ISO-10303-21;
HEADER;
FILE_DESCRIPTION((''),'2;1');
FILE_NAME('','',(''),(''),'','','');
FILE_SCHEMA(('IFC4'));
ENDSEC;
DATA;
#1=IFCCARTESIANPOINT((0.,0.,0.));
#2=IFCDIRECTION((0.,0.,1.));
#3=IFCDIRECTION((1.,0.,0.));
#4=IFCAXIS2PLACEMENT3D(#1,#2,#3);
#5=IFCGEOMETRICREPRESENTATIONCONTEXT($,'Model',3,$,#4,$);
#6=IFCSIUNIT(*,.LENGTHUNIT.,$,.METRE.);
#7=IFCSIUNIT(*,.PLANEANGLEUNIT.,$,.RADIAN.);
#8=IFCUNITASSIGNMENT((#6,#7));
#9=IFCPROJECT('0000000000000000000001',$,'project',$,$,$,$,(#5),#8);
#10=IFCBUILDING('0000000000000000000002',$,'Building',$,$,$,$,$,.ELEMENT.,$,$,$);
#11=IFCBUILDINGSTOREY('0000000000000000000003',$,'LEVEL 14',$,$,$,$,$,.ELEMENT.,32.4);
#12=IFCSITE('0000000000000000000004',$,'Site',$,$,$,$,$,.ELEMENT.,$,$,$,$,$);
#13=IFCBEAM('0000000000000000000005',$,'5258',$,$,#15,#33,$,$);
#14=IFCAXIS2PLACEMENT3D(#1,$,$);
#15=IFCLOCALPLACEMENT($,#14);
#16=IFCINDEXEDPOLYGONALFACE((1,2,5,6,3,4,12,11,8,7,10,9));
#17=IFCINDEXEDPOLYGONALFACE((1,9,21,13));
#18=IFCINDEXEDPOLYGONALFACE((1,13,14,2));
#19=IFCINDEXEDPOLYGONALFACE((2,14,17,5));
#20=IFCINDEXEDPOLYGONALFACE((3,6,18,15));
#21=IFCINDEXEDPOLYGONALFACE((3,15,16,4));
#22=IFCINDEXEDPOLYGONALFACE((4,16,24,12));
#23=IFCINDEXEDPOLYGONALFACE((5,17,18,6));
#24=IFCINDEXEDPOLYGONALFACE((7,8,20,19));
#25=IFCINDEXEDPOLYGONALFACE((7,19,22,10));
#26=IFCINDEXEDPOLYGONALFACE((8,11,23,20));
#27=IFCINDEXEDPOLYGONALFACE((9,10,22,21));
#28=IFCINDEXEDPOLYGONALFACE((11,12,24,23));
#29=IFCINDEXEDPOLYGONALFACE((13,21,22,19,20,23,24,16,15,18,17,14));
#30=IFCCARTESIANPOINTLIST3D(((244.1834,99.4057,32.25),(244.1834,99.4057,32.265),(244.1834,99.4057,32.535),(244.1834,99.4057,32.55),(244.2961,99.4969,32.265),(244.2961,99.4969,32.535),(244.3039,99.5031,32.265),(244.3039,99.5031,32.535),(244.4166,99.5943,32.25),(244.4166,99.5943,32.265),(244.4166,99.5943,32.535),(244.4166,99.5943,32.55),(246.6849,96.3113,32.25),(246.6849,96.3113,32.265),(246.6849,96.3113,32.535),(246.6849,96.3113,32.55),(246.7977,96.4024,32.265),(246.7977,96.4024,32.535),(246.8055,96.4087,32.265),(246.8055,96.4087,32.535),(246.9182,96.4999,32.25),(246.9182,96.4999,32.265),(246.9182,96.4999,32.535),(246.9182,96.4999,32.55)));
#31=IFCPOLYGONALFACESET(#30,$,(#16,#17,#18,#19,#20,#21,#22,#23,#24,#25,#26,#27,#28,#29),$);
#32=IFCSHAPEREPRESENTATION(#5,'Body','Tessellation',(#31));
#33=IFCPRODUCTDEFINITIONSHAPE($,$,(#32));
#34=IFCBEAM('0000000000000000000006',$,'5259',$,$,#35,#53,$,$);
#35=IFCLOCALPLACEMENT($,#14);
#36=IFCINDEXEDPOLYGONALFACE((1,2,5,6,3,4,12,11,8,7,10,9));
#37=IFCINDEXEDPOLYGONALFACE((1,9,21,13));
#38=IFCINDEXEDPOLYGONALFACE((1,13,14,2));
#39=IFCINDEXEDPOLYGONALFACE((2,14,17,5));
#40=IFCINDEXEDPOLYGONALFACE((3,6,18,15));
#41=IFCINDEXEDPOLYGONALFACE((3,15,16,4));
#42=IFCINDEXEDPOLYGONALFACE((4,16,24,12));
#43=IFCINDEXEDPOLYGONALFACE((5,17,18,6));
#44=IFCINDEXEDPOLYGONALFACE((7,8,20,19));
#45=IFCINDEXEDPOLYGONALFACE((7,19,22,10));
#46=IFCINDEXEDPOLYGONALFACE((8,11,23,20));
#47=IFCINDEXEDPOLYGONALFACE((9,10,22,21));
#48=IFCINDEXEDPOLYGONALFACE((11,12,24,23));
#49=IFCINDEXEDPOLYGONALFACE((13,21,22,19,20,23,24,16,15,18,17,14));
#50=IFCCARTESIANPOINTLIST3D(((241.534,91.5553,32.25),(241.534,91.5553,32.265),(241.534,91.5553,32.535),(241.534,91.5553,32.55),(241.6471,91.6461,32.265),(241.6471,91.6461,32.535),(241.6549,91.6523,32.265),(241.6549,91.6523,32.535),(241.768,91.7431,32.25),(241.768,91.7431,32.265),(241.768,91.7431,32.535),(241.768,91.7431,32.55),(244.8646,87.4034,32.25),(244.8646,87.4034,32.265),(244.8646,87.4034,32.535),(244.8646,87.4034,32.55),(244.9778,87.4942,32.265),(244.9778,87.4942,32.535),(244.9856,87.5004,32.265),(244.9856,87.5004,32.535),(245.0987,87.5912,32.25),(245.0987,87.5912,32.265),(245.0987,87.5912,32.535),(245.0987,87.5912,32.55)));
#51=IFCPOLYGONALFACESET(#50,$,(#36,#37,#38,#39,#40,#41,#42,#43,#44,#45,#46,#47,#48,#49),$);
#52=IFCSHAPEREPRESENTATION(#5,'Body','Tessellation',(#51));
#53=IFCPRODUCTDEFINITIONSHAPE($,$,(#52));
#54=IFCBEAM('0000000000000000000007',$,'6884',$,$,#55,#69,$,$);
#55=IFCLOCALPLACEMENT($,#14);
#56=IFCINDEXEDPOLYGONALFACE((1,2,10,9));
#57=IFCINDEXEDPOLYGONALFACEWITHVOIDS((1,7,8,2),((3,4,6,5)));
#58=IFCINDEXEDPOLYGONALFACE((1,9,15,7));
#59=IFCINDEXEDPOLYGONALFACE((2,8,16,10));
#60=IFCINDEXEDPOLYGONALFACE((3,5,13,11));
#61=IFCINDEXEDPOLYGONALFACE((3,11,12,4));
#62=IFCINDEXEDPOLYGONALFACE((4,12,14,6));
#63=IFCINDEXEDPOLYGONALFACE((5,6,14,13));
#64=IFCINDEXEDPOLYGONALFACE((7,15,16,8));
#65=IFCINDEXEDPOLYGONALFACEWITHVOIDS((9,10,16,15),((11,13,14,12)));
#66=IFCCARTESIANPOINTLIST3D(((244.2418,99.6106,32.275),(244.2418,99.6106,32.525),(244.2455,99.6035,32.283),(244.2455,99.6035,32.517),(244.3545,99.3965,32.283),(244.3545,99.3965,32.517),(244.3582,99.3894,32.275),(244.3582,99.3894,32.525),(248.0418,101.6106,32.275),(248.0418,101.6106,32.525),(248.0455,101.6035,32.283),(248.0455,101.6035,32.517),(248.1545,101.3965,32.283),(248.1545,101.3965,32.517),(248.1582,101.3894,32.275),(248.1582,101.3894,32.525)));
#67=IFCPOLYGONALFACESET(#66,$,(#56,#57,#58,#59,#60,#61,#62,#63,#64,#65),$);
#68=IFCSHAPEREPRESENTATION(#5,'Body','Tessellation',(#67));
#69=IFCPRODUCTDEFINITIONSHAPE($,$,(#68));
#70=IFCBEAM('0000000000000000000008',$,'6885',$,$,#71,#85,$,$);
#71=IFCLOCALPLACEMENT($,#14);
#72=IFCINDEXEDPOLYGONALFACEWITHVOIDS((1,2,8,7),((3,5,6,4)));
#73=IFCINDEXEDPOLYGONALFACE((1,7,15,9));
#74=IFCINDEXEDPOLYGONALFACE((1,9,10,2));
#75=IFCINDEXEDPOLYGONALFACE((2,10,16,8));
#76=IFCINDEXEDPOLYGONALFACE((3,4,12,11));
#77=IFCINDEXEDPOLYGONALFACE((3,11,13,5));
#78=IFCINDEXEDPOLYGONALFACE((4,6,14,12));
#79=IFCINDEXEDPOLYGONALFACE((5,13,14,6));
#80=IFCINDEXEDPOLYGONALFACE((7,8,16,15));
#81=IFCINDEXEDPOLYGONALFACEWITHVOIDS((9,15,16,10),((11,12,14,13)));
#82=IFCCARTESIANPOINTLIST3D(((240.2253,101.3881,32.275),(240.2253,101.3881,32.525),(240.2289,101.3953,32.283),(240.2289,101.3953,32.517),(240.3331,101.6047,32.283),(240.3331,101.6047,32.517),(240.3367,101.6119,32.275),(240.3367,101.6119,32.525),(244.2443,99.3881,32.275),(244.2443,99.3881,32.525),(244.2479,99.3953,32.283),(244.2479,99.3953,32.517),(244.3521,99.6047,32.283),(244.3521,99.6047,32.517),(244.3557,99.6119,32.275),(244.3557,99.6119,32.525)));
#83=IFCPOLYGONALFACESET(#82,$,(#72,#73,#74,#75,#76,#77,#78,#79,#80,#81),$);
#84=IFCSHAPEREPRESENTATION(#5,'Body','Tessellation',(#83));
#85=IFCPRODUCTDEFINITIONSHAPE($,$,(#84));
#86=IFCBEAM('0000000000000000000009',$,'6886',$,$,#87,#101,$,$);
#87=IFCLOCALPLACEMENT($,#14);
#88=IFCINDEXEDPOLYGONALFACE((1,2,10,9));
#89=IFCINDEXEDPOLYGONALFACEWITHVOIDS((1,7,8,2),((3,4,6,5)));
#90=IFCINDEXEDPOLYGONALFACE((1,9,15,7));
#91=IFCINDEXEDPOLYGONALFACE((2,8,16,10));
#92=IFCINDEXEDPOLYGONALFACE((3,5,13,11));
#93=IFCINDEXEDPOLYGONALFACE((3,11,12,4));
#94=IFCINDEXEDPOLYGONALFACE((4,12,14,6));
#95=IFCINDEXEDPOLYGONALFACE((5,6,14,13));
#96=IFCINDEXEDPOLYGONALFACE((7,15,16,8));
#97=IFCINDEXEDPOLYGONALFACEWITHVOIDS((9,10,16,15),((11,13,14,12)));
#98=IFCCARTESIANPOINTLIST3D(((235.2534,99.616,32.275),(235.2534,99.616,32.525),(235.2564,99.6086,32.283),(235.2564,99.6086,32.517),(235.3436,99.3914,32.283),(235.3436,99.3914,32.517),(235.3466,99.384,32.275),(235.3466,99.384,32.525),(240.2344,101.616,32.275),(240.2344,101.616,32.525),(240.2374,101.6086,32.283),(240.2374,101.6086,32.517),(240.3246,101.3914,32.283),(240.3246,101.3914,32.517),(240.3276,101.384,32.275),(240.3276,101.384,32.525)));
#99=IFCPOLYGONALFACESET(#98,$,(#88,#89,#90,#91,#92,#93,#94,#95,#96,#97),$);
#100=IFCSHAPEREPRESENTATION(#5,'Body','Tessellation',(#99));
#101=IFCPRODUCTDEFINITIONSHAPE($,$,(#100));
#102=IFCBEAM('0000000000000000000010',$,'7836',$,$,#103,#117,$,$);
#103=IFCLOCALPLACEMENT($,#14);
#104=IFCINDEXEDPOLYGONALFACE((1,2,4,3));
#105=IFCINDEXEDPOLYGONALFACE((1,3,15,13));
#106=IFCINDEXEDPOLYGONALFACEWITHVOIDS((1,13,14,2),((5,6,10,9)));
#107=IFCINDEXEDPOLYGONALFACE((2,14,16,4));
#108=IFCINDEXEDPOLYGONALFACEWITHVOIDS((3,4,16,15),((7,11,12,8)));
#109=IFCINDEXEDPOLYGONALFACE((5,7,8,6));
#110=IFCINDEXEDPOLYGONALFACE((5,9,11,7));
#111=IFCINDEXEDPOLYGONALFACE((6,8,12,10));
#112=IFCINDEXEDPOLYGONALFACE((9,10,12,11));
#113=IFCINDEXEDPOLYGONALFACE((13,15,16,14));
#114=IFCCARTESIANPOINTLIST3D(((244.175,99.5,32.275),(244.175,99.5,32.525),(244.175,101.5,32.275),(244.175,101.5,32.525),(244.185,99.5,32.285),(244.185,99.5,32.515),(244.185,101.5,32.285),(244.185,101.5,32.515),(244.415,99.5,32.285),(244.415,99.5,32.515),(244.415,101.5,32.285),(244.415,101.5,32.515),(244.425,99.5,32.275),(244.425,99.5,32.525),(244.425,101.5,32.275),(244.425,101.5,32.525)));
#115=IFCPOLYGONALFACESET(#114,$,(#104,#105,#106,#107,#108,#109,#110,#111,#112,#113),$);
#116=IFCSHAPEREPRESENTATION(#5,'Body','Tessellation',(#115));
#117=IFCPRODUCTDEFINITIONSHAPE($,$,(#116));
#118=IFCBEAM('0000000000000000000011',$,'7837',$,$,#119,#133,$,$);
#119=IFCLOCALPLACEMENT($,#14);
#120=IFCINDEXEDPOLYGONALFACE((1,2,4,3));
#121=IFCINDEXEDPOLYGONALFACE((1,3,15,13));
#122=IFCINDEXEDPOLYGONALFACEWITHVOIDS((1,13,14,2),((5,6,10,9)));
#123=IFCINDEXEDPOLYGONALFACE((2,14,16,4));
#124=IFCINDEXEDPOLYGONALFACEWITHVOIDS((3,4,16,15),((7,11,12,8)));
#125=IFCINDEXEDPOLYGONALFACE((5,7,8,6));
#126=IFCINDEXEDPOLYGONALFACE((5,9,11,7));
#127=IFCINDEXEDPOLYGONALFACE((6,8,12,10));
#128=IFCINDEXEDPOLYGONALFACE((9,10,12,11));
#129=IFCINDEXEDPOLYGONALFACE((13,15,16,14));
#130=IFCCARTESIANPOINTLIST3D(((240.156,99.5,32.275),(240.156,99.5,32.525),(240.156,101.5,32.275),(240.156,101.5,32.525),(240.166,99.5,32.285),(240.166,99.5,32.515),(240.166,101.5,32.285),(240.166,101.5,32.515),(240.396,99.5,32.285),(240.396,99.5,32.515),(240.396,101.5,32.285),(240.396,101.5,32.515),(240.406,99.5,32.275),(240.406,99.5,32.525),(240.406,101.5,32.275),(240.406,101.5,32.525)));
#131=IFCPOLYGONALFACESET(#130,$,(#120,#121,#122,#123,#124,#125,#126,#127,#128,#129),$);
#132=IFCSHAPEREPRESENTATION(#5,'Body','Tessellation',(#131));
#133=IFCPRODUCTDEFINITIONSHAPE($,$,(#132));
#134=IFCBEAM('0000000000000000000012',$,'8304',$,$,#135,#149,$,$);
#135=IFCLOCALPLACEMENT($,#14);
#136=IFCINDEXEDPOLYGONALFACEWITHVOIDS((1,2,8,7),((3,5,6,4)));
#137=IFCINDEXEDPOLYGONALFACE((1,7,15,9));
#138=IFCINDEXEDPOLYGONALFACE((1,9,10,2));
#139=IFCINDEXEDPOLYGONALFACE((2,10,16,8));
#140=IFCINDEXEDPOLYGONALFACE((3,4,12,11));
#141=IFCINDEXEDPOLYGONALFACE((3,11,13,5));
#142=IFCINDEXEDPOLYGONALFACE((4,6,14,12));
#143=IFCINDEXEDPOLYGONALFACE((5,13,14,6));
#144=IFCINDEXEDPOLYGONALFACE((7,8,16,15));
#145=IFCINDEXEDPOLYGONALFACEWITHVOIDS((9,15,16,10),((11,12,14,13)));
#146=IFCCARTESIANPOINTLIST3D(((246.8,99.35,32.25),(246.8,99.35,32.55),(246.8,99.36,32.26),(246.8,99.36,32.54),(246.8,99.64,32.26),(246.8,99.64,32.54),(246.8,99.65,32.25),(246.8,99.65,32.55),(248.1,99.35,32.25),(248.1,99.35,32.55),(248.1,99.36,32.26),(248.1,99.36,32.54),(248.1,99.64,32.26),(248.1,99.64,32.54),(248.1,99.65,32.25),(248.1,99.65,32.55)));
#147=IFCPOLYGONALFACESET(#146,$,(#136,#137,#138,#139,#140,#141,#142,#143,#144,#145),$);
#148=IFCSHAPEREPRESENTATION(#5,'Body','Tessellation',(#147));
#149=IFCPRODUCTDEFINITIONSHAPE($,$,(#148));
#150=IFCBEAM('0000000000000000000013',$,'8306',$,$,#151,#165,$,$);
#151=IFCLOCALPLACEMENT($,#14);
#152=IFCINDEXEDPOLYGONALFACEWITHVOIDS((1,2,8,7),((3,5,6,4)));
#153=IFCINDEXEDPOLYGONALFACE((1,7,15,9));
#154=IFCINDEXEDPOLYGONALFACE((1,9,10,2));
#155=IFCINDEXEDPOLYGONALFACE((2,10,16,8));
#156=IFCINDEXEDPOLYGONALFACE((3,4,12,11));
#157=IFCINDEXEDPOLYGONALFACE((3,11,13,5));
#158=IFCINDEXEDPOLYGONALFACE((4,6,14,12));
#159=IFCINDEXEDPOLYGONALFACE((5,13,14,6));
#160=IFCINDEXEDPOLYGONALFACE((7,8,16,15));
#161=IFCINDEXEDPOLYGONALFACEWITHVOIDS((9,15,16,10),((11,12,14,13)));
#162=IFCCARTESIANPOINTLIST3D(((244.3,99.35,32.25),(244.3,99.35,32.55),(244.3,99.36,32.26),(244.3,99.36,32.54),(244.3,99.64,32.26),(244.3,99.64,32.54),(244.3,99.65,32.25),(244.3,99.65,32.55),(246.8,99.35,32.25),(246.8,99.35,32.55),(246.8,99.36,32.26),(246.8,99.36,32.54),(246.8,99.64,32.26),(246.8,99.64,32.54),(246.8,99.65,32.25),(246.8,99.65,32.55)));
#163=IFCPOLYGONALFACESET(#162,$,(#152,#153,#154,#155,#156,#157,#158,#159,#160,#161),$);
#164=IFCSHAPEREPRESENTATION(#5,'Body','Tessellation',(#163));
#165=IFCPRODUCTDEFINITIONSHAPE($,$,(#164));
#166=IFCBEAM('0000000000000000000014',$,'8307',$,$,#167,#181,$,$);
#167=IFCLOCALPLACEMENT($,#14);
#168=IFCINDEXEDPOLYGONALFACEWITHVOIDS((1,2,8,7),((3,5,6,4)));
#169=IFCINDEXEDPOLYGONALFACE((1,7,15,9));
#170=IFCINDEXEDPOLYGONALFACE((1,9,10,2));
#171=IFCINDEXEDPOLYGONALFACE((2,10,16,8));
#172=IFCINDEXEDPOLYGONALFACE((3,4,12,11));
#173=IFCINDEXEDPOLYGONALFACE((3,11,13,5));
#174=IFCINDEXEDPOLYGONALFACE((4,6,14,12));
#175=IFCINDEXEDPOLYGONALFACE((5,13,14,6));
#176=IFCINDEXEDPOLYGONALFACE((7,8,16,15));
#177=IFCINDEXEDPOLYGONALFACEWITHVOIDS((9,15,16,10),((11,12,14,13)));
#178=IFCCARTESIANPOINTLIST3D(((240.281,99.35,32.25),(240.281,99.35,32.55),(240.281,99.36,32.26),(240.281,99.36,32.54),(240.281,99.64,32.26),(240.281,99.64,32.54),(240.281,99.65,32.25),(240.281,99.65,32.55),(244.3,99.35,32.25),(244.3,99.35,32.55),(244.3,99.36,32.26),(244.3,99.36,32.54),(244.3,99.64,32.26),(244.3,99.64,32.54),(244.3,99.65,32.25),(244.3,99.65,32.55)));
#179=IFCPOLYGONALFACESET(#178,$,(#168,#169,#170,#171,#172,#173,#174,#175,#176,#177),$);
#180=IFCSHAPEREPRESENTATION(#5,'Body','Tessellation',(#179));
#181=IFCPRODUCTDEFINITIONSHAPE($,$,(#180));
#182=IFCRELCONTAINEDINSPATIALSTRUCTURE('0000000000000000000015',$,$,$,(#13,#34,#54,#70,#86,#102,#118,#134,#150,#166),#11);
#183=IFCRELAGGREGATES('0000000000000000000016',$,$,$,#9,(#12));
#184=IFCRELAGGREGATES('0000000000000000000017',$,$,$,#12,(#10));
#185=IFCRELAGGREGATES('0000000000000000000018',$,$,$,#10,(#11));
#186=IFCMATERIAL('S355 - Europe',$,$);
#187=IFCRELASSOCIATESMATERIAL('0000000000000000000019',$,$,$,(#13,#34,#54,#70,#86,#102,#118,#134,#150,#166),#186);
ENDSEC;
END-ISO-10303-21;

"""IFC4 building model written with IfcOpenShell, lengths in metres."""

from ifc_helpers import new_model, si_unit, frame, origin_with_axes, origin_2d_with_axis, place, context, project, spatial, hollow_rectangle, i_section, extrude, material, material_profile, profile_set, profile_usage, element, save


model = new_model("IFC4")

# Units and contexts
model_context = context("Model", 3, world=origin_with_axes())
ifc_project = project(units=[si_unit("LENGTHUNIT", "METRE"), si_unit("PLANEANGLEUNIT", "RADIAN")], contexts=[model_context])

# Site, building, storey
site = spatial("IfcSite", under=ifc_project, Name="Site", CompositionType="ELEMENT")
building = spatial("IfcBuilding", under=site, Name="Building", CompositionType="ELEMENT")
storey = spatial("IfcBuildingStorey", under=building, Name="LEVEL 14", CompositionType="ELEMENT", Elevation=32.4)

# Shared definitions
ifc_material = material(Name="S355 - Europe")

# Beams
ifc_material_profile_1 = material_profile(ifc_material, i_section(OverallWidth=0.3, OverallDepth=0.3, WebThickness=0.01, FlangeThickness=0.015, at=origin_2d_with_axis()))
ifc_profile_set_1 = profile_set([ifc_material_profile_1])
ifc_profile_usage_1 = profile_usage(ifc_profile_set_1, cardinal=10)
beam_1_placement = place(None, frame((244.3, 99.5, 32.4), z_axis=(0.628678, -0.777665, 0.0), x_axis=(0.777305, 0.629124, 0.0)))
element("IfcBeam", 1, at=beam_1_placement, inside=storey, material=ifc_profile_usage_1, Name="5258", context=model_context, shape_type="SweptSolid", body=[
    extrude(i_section(OverallWidth=0.3, OverallDepth=0.3, WebThickness=0.01, FlangeThickness=0.015, at=origin_2d_with_axis()), origin_with_axes(), (0.0, 0.0, 1.0), 3.9791),
])
ifc_material_profile_2 = material_profile(ifc_material, i_section(OverallWidth=0.3, OverallDepth=0.3, WebThickness=0.01, FlangeThickness=0.015, at=origin_2d_with_axis()))
ifc_profile_set_2 = profile_set([ifc_material_profile_2])
ifc_profile_usage_2 = profile_usage(ifc_profile_set_2, cardinal=10)
beam_2_placement = place(None, frame((241.651, 91.6492, 32.4), z_axis=(0.625741, -0.780031, 0.0), x_axis=(0.779651, 0.626214, 0.0)))
element("IfcBeam", 2, at=beam_2_placement, inside=storey, material=ifc_profile_usage_2, Name="5259", context=model_context, shape_type="SweptSolid", body=[
    extrude(i_section(OverallWidth=0.3, OverallDepth=0.3, WebThickness=0.01, FlangeThickness=0.015, at=origin_2d_with_axis()), origin_with_axes(), (0.0, 0.0, 1.0), 5.3227),
])
ifc_material_profile_3 = material_profile(ifc_material, hollow_rectangle(XDim=0.25, YDim=0.25, WallThickness=0.008, at=origin_2d_with_axis()))
ifc_profile_set_3 = profile_set([ifc_material_profile_3])
ifc_profile_usage_3 = profile_usage(ifc_profile_set_3, cardinal=10)
beam_3_placement = place(None, frame((248.1, 101.5, 32.4), z_axis=(-0.884918, -0.465746, 0.0), x_axis=(0.465746, -0.884918, 0.0)))
element("IfcBeam", 3, at=beam_3_placement, inside=storey, material=ifc_profile_usage_3, Name="6884", context=model_context, shape_type="SweptSolid", body=[
    extrude(hollow_rectangle(XDim=0.25, YDim=0.25, WallThickness=0.008, at=origin_2d_with_axis()), origin_with_axes(), (0.0, 0.0, 1.0), 4.2942),
])
ifc_material_profile_4 = material_profile(ifc_material, hollow_rectangle(XDim=0.25, YDim=0.25, WallThickness=0.008, at=origin_2d_with_axis()))
ifc_profile_set_4 = profile_set([ifc_material_profile_4])
ifc_profile_usage_4 = profile_usage(ifc_profile_set_4, cardinal=10)
beam_4_placement = place(None, frame((244.3, 99.5, 32.4), z_axis=(-0.895272, 0.44552, 0.0), x_axis=(-0.44552, -0.895272, 0.0)))
element("IfcBeam", 4, at=beam_4_placement, inside=storey, material=ifc_profile_usage_4, Name="6885", context=model_context, shape_type="SweptSolid", body=[
    extrude(hollow_rectangle(XDim=0.25, YDim=0.25, WallThickness=0.008, at=origin_2d_with_axis()), origin_with_axes(), (0.0, 0.0, 1.0), 4.4891),
])
ifc_material_profile_5 = material_profile(ifc_material, hollow_rectangle(XDim=0.25, YDim=0.25, WallThickness=0.008, at=origin_2d_with_axis()))
ifc_profile_set_5 = profile_set([ifc_material_profile_5])
ifc_profile_usage_5 = profile_usage(ifc_profile_set_5, cardinal=10)
beam_5_placement = place(None, frame((240.281, 101.5, 32.4), z_axis=(-0.927988, -0.372611, 0.0), x_axis=(0.372611, -0.927988, 0.0)))
element("IfcBeam", 5, at=beam_5_placement, inside=storey, material=ifc_profile_usage_5, Name="6886", context=model_context, shape_type="SweptSolid", body=[
    extrude(hollow_rectangle(XDim=0.25, YDim=0.25, WallThickness=0.008, at=origin_2d_with_axis()), origin_with_axes(), (0.0, 0.0, 1.0), 5.3675),
])
ifc_material_profile_6 = material_profile(ifc_material, hollow_rectangle(XDim=0.25, YDim=0.25, WallThickness=0.01, at=origin_2d_with_axis()))
ifc_profile_set_6 = profile_set([ifc_material_profile_6])
ifc_profile_usage_6 = profile_usage(ifc_profile_set_6, cardinal=10)
beam_6_placement = place(None, frame((244.3, 101.5, 32.4), z_axis=(0.0, -1.0, 0.0), x_axis=(1.0, 0.0, 0.0)))
element("IfcBeam", 6, at=beam_6_placement, inside=storey, material=ifc_profile_usage_6, Name="7836", context=model_context, shape_type="SweptSolid", body=[
    extrude(hollow_rectangle(XDim=0.25, YDim=0.25, WallThickness=0.01, at=origin_2d_with_axis()), origin_with_axes(), (0.0, 0.0, 1.0), 2.0),
])
ifc_material_profile_7 = material_profile(ifc_material, hollow_rectangle(XDim=0.25, YDim=0.25, WallThickness=0.01, at=origin_2d_with_axis()))
ifc_profile_set_7 = profile_set([ifc_material_profile_7])
ifc_profile_usage_7 = profile_usage(ifc_profile_set_7, cardinal=10)
beam_7_placement = place(None, frame((240.281, 101.5, 32.4), z_axis=(0.0, -1.0, 0.0), x_axis=(1.0, 0.0, 0.0)))
element("IfcBeam", 7, at=beam_7_placement, inside=storey, material=ifc_profile_usage_7, Name="7837", context=model_context, shape_type="SweptSolid", body=[
    extrude(hollow_rectangle(XDim=0.25, YDim=0.25, WallThickness=0.01, at=origin_2d_with_axis()), origin_with_axes(), (0.0, 0.0, 1.0), 2.0),
])
ifc_material_profile_8 = material_profile(ifc_material, hollow_rectangle(XDim=0.3, YDim=0.3, WallThickness=0.01, at=origin_2d_with_axis()))
ifc_profile_set_8 = profile_set([ifc_material_profile_8])
ifc_profile_usage_8 = profile_usage(ifc_profile_set_8, cardinal=10)
beam_8_placement = place(None, frame((248.1, 99.5, 32.4), z_axis=(-1.0, 0.0, 0.0), x_axis=(0.0, -1.0, 0.0)))
element("IfcBeam", 8, at=beam_8_placement, inside=storey, material=ifc_profile_usage_8, Name="8304", context=model_context, shape_type="SweptSolid", body=[
    extrude(hollow_rectangle(XDim=0.3, YDim=0.3, WallThickness=0.01, at=origin_2d_with_axis()), origin_with_axes(), (0.0, 0.0, 1.0), 1.3),
])
ifc_material_profile_9 = material_profile(ifc_material, hollow_rectangle(XDim=0.3, YDim=0.3, WallThickness=0.01, at=origin_2d_with_axis()))
ifc_profile_set_9 = profile_set([ifc_material_profile_9])
ifc_profile_usage_9 = profile_usage(ifc_profile_set_9, cardinal=10)
beam_9_placement = place(None, frame((246.8, 99.5, 32.4), z_axis=(-1.0, 0.0, 0.0), x_axis=(0.0, -1.0, 0.0)))
element("IfcBeam", 9, at=beam_9_placement, inside=storey, material=ifc_profile_usage_9, Name="8306", context=model_context, shape_type="SweptSolid", body=[
    extrude(hollow_rectangle(XDim=0.3, YDim=0.3, WallThickness=0.01, at=origin_2d_with_axis()), origin_with_axes(), (0.0, 0.0, 1.0), 2.5),
])
ifc_material_profile_10 = material_profile(ifc_material, hollow_rectangle(XDim=0.3, YDim=0.3, WallThickness=0.01, at=origin_2d_with_axis()))
ifc_profile_set_10 = profile_set([ifc_material_profile_10])
ifc_profile_usage_10 = profile_usage(ifc_profile_set_10, cardinal=10)
beam_10_placement = place(None, frame((244.3, 99.5, 32.4), z_axis=(-1.0, 0.0, 0.0), x_axis=(0.0, -1.0, 0.0)))
element("IfcBeam", 10, at=beam_10_placement, inside=storey, material=ifc_profile_usage_10, Name="8307", context=model_context, shape_type="SweptSolid", body=[
    extrude(hollow_rectangle(XDim=0.3, YDim=0.3, WallThickness=0.01, at=origin_2d_with_axis()), origin_with_axes(), (0.0, 0.0, 1.0), 4.019),
])

save(model, "model.ifc")
